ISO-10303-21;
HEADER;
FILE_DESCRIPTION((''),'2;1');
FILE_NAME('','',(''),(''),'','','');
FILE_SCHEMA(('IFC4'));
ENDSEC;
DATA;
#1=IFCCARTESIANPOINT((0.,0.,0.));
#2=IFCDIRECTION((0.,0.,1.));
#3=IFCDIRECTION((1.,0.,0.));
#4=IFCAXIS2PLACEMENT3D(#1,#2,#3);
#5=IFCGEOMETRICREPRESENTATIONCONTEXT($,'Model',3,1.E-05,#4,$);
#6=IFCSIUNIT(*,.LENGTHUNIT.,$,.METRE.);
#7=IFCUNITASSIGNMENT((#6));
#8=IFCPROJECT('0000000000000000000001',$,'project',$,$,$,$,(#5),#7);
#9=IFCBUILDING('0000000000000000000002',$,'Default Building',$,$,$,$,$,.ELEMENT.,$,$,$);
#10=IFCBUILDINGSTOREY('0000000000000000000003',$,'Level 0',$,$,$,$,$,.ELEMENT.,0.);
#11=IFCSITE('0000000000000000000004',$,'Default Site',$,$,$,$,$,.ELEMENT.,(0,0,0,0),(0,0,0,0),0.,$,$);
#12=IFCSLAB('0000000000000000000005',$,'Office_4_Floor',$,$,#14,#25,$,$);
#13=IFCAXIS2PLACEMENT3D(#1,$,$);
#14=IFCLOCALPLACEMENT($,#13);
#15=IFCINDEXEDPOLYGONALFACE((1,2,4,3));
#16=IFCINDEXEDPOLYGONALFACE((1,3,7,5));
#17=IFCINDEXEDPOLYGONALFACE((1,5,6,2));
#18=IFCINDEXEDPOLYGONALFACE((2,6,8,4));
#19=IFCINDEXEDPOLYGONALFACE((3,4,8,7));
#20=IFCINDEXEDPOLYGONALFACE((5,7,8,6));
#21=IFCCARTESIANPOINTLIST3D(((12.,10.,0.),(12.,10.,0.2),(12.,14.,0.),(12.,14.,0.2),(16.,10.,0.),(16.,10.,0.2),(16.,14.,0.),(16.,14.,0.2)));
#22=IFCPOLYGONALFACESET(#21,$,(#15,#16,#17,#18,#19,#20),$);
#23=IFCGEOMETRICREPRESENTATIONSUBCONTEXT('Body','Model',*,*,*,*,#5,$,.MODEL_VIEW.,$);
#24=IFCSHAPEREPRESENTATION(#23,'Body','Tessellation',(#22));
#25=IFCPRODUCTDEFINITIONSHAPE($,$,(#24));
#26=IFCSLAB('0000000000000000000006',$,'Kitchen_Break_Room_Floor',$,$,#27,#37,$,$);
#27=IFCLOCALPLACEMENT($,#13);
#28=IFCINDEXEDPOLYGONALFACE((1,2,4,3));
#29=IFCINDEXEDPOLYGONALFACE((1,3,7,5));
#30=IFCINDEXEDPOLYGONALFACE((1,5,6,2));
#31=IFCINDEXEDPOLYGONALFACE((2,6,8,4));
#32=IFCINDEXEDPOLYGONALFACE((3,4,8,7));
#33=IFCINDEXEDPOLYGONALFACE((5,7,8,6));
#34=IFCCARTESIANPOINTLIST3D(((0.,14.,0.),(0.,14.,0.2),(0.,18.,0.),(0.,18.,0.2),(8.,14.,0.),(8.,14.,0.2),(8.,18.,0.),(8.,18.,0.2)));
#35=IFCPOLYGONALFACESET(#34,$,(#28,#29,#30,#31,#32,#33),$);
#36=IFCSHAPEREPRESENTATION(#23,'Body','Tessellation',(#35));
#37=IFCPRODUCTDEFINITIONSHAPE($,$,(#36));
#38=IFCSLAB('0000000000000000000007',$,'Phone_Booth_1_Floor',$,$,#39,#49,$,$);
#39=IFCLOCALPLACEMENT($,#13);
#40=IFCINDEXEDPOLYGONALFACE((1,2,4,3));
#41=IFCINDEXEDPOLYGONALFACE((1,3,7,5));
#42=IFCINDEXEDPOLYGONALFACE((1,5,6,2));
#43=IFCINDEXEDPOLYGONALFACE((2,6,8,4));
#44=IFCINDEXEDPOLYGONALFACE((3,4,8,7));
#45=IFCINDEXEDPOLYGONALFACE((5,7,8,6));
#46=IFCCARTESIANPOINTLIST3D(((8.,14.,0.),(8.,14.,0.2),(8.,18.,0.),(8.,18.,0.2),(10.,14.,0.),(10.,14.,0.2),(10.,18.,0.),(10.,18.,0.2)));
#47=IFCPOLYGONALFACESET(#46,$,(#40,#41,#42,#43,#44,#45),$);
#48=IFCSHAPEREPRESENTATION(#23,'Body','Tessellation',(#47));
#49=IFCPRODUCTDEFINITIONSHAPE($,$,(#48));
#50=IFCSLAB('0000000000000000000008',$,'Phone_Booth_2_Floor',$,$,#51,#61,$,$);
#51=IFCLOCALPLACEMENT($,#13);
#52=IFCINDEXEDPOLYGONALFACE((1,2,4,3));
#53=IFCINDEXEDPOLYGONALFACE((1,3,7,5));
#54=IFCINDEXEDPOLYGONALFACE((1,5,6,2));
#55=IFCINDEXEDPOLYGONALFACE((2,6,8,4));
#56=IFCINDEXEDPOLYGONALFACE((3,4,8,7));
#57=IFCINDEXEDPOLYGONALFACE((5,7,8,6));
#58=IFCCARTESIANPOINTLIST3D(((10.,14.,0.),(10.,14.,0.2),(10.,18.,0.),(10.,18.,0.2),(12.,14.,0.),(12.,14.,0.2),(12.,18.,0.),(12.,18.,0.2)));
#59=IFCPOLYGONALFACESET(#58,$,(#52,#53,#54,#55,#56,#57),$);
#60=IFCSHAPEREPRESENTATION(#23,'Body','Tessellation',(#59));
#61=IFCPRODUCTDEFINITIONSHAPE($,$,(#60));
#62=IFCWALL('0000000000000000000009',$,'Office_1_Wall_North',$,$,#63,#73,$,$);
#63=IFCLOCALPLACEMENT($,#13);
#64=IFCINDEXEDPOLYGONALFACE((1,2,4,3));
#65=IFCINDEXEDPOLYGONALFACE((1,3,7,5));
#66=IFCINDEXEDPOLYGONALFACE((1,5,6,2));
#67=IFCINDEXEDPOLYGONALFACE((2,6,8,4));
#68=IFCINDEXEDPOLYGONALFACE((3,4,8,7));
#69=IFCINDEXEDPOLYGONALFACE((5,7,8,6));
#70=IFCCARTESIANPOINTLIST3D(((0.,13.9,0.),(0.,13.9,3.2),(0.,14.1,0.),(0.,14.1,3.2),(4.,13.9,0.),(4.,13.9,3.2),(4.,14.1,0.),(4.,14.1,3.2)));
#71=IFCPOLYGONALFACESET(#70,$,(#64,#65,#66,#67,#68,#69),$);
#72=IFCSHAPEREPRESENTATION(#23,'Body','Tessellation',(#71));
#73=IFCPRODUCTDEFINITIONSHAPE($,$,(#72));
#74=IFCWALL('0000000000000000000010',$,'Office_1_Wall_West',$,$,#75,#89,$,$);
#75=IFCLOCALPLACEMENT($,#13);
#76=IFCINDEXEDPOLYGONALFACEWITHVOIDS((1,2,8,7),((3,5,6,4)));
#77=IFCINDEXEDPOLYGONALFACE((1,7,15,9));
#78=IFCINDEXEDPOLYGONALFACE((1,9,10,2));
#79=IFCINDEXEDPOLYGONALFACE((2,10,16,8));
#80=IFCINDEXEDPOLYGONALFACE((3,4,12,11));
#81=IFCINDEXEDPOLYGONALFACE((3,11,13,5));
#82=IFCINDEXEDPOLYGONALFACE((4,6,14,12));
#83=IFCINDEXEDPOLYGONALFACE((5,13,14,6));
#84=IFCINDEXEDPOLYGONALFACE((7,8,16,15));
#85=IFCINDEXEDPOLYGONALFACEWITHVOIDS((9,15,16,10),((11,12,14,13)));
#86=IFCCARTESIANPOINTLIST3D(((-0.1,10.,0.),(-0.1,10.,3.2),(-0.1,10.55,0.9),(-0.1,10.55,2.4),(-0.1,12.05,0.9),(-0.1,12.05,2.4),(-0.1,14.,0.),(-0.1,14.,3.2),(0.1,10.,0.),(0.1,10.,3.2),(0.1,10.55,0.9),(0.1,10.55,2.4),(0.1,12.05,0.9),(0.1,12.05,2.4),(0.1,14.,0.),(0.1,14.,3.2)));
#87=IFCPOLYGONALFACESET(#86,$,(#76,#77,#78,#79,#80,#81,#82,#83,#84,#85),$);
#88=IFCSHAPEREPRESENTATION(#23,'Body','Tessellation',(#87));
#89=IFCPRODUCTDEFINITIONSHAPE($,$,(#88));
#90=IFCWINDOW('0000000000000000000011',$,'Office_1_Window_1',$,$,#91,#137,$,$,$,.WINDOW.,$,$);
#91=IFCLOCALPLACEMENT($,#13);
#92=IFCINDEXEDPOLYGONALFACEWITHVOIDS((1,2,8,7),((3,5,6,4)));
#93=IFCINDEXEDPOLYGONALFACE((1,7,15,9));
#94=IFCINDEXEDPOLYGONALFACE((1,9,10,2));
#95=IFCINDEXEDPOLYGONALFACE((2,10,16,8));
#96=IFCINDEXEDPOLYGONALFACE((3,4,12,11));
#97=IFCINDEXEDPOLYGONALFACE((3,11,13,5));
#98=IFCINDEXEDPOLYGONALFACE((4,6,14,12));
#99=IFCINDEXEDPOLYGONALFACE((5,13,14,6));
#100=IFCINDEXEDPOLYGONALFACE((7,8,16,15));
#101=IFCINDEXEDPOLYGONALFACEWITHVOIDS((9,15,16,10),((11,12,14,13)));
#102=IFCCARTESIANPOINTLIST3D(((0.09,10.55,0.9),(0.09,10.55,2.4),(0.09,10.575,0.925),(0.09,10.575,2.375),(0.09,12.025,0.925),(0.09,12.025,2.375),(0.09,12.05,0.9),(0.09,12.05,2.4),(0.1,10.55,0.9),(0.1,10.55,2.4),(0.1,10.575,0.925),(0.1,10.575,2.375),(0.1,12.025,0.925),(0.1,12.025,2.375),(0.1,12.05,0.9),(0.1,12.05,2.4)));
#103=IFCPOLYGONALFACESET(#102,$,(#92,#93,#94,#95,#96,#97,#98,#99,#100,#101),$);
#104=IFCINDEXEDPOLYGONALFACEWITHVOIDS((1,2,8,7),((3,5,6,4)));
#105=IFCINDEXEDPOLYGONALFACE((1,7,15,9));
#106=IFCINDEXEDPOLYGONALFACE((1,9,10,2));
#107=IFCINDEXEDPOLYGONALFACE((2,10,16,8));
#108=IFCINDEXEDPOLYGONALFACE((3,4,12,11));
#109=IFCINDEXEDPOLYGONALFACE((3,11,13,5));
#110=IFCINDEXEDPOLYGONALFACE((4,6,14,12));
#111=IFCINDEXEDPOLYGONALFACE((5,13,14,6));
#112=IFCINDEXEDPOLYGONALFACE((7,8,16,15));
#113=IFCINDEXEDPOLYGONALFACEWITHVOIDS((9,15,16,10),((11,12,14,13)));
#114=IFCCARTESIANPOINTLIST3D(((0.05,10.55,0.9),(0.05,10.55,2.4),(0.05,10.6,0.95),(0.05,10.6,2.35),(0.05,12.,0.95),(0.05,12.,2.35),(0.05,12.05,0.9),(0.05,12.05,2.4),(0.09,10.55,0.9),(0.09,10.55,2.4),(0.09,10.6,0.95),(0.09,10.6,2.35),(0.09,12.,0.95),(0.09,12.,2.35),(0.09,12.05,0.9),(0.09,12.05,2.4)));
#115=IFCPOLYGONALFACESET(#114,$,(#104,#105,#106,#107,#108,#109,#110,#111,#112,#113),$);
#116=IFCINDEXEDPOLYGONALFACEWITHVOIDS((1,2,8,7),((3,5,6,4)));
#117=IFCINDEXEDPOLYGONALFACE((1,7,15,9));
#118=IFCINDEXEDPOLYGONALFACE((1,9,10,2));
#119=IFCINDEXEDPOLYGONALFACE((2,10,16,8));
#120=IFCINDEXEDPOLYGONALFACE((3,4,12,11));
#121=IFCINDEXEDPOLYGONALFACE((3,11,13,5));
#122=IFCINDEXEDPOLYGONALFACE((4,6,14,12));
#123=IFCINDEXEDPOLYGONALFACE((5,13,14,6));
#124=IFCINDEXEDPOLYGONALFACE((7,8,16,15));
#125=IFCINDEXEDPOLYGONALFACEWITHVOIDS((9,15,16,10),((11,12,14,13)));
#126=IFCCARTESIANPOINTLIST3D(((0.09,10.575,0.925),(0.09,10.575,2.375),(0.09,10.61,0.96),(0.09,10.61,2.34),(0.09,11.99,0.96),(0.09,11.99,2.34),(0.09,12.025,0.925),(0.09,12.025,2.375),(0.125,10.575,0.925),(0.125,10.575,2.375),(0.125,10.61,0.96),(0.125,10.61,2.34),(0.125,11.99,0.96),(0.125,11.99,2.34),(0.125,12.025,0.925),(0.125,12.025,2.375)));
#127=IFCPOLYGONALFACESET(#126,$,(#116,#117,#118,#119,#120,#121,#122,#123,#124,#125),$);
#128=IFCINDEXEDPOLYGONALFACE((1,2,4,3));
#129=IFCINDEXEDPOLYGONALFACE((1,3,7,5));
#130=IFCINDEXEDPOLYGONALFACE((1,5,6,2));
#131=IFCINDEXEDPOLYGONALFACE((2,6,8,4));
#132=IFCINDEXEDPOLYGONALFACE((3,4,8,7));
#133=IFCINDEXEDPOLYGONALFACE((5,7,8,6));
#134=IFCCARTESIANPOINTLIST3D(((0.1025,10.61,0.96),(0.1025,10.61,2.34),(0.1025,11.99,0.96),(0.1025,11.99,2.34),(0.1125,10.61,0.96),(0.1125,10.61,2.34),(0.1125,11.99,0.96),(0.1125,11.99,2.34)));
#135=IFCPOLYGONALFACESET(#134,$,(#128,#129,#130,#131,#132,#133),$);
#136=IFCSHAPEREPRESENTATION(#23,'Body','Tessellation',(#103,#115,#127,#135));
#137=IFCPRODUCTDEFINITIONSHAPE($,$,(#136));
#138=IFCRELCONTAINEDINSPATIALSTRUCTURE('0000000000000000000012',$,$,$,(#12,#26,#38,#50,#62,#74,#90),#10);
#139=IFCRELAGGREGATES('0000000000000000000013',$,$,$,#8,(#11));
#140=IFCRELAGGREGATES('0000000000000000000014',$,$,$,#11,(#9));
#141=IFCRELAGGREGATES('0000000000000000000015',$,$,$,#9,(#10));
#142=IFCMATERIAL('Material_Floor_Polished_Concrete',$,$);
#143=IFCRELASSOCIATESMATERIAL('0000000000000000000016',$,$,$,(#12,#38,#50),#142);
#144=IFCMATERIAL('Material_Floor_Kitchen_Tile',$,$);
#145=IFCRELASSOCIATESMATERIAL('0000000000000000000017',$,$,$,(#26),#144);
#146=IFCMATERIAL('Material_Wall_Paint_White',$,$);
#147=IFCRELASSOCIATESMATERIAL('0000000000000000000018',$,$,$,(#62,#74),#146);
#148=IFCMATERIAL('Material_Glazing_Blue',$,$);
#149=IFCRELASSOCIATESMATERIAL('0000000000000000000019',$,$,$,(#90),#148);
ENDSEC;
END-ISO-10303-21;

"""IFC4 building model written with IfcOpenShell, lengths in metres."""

from ifc_helpers import new_model, si_unit, frame, origin_with_axes, place, context, subcontext, project, spatial, line, indexed_curve, outline, extrude, material, element, fill, save


model = new_model("IFC4")

# Units and contexts
model_context = context("Model", 3, precision=1e-05, world=origin_with_axes())
body_context = subcontext(model_context, "Body", "Model", "MODEL_VIEW")
ifc_project = project(units=[si_unit("LENGTHUNIT", "METRE")], contexts=[model_context])

# Site, building, storey
site = spatial("IfcSite", under=ifc_project, Name="Default Site", CompositionType="ELEMENT", RefLatitude=(0, 0, 0, 0), RefLongitude=(0, 0, 0, 0), RefElevation=0.0)
building = spatial("IfcBuilding", under=site, Name="Default Building", CompositionType="ELEMENT")
storey = spatial("IfcBuildingStorey", under=building, Name="Level 0", CompositionType="ELEMENT", Elevation=0.0)

# Slabs
ifc_material_1 = material(Name="Material_Floor_Polished_Concrete")
slab_1_placement = place(None, frame((12.0, 10.0, 0.0), z_axis=(0.0, 0.0, 1.0), x_axis=(1.0, 0.0, 0.0)))
element("IfcSlab", 1, at=slab_1_placement, inside=storey, material=ifc_material_1, Name="Office_4_Floor", context=body_context, shape_type="SweptSolid", body=[
    extrude(outline(indexed_curve([(0.0, 0.0), (4.0, 0.0), (4.0, 4.0), (0.0, 4.0)])), None, (0.0, 0.0, 1.0), 0.2),
])
ifc_material_2 = material(Name="Material_Floor_Kitchen_Tile")
slab_2_placement = place(None, frame((0.0, 14.0, 0.0), z_axis=(0.0, 0.0, 1.0), x_axis=(1.0, 0.0, 0.0)))
element("IfcSlab", 2, at=slab_2_placement, inside=storey, material=ifc_material_2, Name="Kitchen_Break_Room_Floor", context=body_context, shape_type="SweptSolid", body=[
    extrude(outline(indexed_curve([(0.0, 0.0), (8.0, 0.0), (8.0, 4.0), (0.0, 4.0)])), None, (0.0, 0.0, 1.0), 0.2),
])
for number, where, z_axis, x_axis, name in (
    (3, (8.0, 14.0, 0.0), (0.0, 0.0, 1.0), (1.0, 0.0, 0.0), "Phone_Booth_1_Floor"),
    (4, (10.0, 14.0, 0.0), (0.0, 0.0, 1.0), (1.0, 0.0, 0.0), "Phone_Booth_2_Floor"),
):
    element("IfcSlab", number, at=place(None, frame(where, z_axis=z_axis, x_axis=x_axis)), inside=storey, material=ifc_material_1, Name=name, context=body_context, shape_type="SweptSolid", body=[
        extrude(outline(indexed_curve([(0.0, 0.0), (2.0, 0.0), (2.0, 4.0), (0.0, 4.0)])), None, (0.0, 0.0, 1.0), 0.2),
    ])

# Wall
ifc_material_3 = material(Name="Material_Wall_Paint_White")
wall_1_placement = place(None, frame((4.0, 14.0, 0.0), z_axis=(0.0, 0.0, 1.0), x_axis=(-1.0, 0.0, 0.0)))
element("IfcWall", 5, at=wall_1_placement, inside=storey, material=ifc_material_3, Name="Office_1_Wall_North", context=body_context, shape_type="SweptSolid", body=[
    extrude(outline(indexed_curve([(0.0, 0.0), (0.0, 0.2), (4.0, 0.2), (4.0, 0.0), (0.0, 0.0)], self_intersect=False)), frame((0.0, -0.1, 0.0), z_axis=(0.0, 0.0, 1.0), x_axis=(1.0, 0.0, 0.0)), (0.0, 0.0, 1.0), 3.2),
])

# Wall, opening, window
wall_2_placement = place(None, frame((0.0, 14.0, 0.0), z_axis=(0.0, 0.0, 1.0), x_axis=(0.0, -1.0, 0.0)))
wall_2 = element("IfcWall", 6, at=wall_2_placement, inside=storey, material=ifc_material_3, Name="Office_1_Wall_West", context=body_context, shape_type="SweptSolid", body=[
    extrude(outline(indexed_curve([(0.0, 0.0), (0.0, 0.2), (4.0, 0.2), (4.0, 0.0), (0.0, 0.0)], self_intersect=False)), frame((0.0, -0.1, 0.0), z_axis=(0.0, 0.0, 1.0), x_axis=(1.0, 0.0, 0.0)), (0.0, 0.0, 1.0), 3.2),
])
opening_1_placement = place(wall_2_placement, frame((1.95, -0.5, 0.9), z_axis=(0.0, 0.0, 1.0), x_axis=(1.0, 0.0, 0.0)))
opening_1 = element("IfcOpeningElement", 7, at=opening_1_placement, inside=storey, cuts=wall_2, PredefinedType="OPENING", context=body_context, shape_type="SweptSolid", body=[
    extrude(outline(indexed_curve([(0.0, 0.0), (0.0, 1.0), (1.5, 1.0), (1.5, 0.0), (0.0, 0.0)], self_intersect=False)), origin_with_axes(), (0.0, 0.0, 1.0), 1.5),
])
ifc_material_4 = material(Name="Material_Glazing_Blue")
window_1_placement = place(None, frame((0.0, 12.05, 0.9), z_axis=(0.0, 0.0, 1.0), x_axis=(0.0, -1.0, 0.0)))
window_1 = element("IfcWindow", 8, at=window_1_placement, inside=storey, material=ifc_material_4, Name="Office_1_Window_1", PredefinedType="WINDOW", context=body_context, shape_type="SweptSolid", body=[
    extrude(outline(indexed_curve([(0.0, 0.0), (1.5, 0.0), (1.5, 1.5), (0.0, 1.5)], segments=[line(1, 2, 3, 4, 1)]), holes=[indexed_curve([(0.025, 0.025), (1.475, 0.025), (1.475, 1.475), (0.025, 1.475)], segments=[line(1, 2, 3, 4, 1)])]), frame((0.0, 0.09, 0.0), z_axis=(0.0, -1.0, 0.0), x_axis=(1.0, 0.0, 0.0)), (0.0, 0.0, -1.0), 0.01),
    extrude(outline(indexed_curve([(0.0, 0.0), (1.5, 0.0), (1.5, 1.5), (0.0, 1.5)], segments=[line(1, 2, 3, 4, 1)]), holes=[indexed_curve([(0.05, 0.05), (1.45, 0.05), (1.45, 1.45), (0.05, 1.45)], segments=[line(1, 2, 3, 4, 1)])]), frame((0.0, 0.05, 0.0), z_axis=(0.0, -1.0, 0.0), x_axis=(1.0, 0.0, 0.0)), (0.0, 0.0, -1.0), 0.04),
    extrude(outline(indexed_curve([(0.0, 0.0), (1.45, 0.0), (1.45, 1.45), (0.0, 1.45)], segments=[line(1, 2, 3, 4, 1)]), holes=[indexed_curve([(0.035, 0.035), (1.415, 0.035), (1.415, 1.415), (0.035, 1.415)], segments=[line(1, 2, 3, 4, 1)])]), frame((0.025, 0.09, 0.025), z_axis=(0.0, -1.0, 0.0), x_axis=(1.0, 0.0, 0.0)), (0.0, 0.0, -1.0), 0.035),
    extrude(outline(indexed_curve([(0.035, 0.035), (1.415, 0.035), (1.415, 1.415), (0.035, 1.415)], segments=[line(1, 2, 3, 4, 1)])), frame((0.025, 0.1025, 0.025), z_axis=(0.0, -1.0, 0.0), x_axis=(1.0, 0.0, 0.0)), (0.0, 0.0, -1.0), 0.01),
])
fill(opening_1, window_1)

save(model, "model.ifc")
